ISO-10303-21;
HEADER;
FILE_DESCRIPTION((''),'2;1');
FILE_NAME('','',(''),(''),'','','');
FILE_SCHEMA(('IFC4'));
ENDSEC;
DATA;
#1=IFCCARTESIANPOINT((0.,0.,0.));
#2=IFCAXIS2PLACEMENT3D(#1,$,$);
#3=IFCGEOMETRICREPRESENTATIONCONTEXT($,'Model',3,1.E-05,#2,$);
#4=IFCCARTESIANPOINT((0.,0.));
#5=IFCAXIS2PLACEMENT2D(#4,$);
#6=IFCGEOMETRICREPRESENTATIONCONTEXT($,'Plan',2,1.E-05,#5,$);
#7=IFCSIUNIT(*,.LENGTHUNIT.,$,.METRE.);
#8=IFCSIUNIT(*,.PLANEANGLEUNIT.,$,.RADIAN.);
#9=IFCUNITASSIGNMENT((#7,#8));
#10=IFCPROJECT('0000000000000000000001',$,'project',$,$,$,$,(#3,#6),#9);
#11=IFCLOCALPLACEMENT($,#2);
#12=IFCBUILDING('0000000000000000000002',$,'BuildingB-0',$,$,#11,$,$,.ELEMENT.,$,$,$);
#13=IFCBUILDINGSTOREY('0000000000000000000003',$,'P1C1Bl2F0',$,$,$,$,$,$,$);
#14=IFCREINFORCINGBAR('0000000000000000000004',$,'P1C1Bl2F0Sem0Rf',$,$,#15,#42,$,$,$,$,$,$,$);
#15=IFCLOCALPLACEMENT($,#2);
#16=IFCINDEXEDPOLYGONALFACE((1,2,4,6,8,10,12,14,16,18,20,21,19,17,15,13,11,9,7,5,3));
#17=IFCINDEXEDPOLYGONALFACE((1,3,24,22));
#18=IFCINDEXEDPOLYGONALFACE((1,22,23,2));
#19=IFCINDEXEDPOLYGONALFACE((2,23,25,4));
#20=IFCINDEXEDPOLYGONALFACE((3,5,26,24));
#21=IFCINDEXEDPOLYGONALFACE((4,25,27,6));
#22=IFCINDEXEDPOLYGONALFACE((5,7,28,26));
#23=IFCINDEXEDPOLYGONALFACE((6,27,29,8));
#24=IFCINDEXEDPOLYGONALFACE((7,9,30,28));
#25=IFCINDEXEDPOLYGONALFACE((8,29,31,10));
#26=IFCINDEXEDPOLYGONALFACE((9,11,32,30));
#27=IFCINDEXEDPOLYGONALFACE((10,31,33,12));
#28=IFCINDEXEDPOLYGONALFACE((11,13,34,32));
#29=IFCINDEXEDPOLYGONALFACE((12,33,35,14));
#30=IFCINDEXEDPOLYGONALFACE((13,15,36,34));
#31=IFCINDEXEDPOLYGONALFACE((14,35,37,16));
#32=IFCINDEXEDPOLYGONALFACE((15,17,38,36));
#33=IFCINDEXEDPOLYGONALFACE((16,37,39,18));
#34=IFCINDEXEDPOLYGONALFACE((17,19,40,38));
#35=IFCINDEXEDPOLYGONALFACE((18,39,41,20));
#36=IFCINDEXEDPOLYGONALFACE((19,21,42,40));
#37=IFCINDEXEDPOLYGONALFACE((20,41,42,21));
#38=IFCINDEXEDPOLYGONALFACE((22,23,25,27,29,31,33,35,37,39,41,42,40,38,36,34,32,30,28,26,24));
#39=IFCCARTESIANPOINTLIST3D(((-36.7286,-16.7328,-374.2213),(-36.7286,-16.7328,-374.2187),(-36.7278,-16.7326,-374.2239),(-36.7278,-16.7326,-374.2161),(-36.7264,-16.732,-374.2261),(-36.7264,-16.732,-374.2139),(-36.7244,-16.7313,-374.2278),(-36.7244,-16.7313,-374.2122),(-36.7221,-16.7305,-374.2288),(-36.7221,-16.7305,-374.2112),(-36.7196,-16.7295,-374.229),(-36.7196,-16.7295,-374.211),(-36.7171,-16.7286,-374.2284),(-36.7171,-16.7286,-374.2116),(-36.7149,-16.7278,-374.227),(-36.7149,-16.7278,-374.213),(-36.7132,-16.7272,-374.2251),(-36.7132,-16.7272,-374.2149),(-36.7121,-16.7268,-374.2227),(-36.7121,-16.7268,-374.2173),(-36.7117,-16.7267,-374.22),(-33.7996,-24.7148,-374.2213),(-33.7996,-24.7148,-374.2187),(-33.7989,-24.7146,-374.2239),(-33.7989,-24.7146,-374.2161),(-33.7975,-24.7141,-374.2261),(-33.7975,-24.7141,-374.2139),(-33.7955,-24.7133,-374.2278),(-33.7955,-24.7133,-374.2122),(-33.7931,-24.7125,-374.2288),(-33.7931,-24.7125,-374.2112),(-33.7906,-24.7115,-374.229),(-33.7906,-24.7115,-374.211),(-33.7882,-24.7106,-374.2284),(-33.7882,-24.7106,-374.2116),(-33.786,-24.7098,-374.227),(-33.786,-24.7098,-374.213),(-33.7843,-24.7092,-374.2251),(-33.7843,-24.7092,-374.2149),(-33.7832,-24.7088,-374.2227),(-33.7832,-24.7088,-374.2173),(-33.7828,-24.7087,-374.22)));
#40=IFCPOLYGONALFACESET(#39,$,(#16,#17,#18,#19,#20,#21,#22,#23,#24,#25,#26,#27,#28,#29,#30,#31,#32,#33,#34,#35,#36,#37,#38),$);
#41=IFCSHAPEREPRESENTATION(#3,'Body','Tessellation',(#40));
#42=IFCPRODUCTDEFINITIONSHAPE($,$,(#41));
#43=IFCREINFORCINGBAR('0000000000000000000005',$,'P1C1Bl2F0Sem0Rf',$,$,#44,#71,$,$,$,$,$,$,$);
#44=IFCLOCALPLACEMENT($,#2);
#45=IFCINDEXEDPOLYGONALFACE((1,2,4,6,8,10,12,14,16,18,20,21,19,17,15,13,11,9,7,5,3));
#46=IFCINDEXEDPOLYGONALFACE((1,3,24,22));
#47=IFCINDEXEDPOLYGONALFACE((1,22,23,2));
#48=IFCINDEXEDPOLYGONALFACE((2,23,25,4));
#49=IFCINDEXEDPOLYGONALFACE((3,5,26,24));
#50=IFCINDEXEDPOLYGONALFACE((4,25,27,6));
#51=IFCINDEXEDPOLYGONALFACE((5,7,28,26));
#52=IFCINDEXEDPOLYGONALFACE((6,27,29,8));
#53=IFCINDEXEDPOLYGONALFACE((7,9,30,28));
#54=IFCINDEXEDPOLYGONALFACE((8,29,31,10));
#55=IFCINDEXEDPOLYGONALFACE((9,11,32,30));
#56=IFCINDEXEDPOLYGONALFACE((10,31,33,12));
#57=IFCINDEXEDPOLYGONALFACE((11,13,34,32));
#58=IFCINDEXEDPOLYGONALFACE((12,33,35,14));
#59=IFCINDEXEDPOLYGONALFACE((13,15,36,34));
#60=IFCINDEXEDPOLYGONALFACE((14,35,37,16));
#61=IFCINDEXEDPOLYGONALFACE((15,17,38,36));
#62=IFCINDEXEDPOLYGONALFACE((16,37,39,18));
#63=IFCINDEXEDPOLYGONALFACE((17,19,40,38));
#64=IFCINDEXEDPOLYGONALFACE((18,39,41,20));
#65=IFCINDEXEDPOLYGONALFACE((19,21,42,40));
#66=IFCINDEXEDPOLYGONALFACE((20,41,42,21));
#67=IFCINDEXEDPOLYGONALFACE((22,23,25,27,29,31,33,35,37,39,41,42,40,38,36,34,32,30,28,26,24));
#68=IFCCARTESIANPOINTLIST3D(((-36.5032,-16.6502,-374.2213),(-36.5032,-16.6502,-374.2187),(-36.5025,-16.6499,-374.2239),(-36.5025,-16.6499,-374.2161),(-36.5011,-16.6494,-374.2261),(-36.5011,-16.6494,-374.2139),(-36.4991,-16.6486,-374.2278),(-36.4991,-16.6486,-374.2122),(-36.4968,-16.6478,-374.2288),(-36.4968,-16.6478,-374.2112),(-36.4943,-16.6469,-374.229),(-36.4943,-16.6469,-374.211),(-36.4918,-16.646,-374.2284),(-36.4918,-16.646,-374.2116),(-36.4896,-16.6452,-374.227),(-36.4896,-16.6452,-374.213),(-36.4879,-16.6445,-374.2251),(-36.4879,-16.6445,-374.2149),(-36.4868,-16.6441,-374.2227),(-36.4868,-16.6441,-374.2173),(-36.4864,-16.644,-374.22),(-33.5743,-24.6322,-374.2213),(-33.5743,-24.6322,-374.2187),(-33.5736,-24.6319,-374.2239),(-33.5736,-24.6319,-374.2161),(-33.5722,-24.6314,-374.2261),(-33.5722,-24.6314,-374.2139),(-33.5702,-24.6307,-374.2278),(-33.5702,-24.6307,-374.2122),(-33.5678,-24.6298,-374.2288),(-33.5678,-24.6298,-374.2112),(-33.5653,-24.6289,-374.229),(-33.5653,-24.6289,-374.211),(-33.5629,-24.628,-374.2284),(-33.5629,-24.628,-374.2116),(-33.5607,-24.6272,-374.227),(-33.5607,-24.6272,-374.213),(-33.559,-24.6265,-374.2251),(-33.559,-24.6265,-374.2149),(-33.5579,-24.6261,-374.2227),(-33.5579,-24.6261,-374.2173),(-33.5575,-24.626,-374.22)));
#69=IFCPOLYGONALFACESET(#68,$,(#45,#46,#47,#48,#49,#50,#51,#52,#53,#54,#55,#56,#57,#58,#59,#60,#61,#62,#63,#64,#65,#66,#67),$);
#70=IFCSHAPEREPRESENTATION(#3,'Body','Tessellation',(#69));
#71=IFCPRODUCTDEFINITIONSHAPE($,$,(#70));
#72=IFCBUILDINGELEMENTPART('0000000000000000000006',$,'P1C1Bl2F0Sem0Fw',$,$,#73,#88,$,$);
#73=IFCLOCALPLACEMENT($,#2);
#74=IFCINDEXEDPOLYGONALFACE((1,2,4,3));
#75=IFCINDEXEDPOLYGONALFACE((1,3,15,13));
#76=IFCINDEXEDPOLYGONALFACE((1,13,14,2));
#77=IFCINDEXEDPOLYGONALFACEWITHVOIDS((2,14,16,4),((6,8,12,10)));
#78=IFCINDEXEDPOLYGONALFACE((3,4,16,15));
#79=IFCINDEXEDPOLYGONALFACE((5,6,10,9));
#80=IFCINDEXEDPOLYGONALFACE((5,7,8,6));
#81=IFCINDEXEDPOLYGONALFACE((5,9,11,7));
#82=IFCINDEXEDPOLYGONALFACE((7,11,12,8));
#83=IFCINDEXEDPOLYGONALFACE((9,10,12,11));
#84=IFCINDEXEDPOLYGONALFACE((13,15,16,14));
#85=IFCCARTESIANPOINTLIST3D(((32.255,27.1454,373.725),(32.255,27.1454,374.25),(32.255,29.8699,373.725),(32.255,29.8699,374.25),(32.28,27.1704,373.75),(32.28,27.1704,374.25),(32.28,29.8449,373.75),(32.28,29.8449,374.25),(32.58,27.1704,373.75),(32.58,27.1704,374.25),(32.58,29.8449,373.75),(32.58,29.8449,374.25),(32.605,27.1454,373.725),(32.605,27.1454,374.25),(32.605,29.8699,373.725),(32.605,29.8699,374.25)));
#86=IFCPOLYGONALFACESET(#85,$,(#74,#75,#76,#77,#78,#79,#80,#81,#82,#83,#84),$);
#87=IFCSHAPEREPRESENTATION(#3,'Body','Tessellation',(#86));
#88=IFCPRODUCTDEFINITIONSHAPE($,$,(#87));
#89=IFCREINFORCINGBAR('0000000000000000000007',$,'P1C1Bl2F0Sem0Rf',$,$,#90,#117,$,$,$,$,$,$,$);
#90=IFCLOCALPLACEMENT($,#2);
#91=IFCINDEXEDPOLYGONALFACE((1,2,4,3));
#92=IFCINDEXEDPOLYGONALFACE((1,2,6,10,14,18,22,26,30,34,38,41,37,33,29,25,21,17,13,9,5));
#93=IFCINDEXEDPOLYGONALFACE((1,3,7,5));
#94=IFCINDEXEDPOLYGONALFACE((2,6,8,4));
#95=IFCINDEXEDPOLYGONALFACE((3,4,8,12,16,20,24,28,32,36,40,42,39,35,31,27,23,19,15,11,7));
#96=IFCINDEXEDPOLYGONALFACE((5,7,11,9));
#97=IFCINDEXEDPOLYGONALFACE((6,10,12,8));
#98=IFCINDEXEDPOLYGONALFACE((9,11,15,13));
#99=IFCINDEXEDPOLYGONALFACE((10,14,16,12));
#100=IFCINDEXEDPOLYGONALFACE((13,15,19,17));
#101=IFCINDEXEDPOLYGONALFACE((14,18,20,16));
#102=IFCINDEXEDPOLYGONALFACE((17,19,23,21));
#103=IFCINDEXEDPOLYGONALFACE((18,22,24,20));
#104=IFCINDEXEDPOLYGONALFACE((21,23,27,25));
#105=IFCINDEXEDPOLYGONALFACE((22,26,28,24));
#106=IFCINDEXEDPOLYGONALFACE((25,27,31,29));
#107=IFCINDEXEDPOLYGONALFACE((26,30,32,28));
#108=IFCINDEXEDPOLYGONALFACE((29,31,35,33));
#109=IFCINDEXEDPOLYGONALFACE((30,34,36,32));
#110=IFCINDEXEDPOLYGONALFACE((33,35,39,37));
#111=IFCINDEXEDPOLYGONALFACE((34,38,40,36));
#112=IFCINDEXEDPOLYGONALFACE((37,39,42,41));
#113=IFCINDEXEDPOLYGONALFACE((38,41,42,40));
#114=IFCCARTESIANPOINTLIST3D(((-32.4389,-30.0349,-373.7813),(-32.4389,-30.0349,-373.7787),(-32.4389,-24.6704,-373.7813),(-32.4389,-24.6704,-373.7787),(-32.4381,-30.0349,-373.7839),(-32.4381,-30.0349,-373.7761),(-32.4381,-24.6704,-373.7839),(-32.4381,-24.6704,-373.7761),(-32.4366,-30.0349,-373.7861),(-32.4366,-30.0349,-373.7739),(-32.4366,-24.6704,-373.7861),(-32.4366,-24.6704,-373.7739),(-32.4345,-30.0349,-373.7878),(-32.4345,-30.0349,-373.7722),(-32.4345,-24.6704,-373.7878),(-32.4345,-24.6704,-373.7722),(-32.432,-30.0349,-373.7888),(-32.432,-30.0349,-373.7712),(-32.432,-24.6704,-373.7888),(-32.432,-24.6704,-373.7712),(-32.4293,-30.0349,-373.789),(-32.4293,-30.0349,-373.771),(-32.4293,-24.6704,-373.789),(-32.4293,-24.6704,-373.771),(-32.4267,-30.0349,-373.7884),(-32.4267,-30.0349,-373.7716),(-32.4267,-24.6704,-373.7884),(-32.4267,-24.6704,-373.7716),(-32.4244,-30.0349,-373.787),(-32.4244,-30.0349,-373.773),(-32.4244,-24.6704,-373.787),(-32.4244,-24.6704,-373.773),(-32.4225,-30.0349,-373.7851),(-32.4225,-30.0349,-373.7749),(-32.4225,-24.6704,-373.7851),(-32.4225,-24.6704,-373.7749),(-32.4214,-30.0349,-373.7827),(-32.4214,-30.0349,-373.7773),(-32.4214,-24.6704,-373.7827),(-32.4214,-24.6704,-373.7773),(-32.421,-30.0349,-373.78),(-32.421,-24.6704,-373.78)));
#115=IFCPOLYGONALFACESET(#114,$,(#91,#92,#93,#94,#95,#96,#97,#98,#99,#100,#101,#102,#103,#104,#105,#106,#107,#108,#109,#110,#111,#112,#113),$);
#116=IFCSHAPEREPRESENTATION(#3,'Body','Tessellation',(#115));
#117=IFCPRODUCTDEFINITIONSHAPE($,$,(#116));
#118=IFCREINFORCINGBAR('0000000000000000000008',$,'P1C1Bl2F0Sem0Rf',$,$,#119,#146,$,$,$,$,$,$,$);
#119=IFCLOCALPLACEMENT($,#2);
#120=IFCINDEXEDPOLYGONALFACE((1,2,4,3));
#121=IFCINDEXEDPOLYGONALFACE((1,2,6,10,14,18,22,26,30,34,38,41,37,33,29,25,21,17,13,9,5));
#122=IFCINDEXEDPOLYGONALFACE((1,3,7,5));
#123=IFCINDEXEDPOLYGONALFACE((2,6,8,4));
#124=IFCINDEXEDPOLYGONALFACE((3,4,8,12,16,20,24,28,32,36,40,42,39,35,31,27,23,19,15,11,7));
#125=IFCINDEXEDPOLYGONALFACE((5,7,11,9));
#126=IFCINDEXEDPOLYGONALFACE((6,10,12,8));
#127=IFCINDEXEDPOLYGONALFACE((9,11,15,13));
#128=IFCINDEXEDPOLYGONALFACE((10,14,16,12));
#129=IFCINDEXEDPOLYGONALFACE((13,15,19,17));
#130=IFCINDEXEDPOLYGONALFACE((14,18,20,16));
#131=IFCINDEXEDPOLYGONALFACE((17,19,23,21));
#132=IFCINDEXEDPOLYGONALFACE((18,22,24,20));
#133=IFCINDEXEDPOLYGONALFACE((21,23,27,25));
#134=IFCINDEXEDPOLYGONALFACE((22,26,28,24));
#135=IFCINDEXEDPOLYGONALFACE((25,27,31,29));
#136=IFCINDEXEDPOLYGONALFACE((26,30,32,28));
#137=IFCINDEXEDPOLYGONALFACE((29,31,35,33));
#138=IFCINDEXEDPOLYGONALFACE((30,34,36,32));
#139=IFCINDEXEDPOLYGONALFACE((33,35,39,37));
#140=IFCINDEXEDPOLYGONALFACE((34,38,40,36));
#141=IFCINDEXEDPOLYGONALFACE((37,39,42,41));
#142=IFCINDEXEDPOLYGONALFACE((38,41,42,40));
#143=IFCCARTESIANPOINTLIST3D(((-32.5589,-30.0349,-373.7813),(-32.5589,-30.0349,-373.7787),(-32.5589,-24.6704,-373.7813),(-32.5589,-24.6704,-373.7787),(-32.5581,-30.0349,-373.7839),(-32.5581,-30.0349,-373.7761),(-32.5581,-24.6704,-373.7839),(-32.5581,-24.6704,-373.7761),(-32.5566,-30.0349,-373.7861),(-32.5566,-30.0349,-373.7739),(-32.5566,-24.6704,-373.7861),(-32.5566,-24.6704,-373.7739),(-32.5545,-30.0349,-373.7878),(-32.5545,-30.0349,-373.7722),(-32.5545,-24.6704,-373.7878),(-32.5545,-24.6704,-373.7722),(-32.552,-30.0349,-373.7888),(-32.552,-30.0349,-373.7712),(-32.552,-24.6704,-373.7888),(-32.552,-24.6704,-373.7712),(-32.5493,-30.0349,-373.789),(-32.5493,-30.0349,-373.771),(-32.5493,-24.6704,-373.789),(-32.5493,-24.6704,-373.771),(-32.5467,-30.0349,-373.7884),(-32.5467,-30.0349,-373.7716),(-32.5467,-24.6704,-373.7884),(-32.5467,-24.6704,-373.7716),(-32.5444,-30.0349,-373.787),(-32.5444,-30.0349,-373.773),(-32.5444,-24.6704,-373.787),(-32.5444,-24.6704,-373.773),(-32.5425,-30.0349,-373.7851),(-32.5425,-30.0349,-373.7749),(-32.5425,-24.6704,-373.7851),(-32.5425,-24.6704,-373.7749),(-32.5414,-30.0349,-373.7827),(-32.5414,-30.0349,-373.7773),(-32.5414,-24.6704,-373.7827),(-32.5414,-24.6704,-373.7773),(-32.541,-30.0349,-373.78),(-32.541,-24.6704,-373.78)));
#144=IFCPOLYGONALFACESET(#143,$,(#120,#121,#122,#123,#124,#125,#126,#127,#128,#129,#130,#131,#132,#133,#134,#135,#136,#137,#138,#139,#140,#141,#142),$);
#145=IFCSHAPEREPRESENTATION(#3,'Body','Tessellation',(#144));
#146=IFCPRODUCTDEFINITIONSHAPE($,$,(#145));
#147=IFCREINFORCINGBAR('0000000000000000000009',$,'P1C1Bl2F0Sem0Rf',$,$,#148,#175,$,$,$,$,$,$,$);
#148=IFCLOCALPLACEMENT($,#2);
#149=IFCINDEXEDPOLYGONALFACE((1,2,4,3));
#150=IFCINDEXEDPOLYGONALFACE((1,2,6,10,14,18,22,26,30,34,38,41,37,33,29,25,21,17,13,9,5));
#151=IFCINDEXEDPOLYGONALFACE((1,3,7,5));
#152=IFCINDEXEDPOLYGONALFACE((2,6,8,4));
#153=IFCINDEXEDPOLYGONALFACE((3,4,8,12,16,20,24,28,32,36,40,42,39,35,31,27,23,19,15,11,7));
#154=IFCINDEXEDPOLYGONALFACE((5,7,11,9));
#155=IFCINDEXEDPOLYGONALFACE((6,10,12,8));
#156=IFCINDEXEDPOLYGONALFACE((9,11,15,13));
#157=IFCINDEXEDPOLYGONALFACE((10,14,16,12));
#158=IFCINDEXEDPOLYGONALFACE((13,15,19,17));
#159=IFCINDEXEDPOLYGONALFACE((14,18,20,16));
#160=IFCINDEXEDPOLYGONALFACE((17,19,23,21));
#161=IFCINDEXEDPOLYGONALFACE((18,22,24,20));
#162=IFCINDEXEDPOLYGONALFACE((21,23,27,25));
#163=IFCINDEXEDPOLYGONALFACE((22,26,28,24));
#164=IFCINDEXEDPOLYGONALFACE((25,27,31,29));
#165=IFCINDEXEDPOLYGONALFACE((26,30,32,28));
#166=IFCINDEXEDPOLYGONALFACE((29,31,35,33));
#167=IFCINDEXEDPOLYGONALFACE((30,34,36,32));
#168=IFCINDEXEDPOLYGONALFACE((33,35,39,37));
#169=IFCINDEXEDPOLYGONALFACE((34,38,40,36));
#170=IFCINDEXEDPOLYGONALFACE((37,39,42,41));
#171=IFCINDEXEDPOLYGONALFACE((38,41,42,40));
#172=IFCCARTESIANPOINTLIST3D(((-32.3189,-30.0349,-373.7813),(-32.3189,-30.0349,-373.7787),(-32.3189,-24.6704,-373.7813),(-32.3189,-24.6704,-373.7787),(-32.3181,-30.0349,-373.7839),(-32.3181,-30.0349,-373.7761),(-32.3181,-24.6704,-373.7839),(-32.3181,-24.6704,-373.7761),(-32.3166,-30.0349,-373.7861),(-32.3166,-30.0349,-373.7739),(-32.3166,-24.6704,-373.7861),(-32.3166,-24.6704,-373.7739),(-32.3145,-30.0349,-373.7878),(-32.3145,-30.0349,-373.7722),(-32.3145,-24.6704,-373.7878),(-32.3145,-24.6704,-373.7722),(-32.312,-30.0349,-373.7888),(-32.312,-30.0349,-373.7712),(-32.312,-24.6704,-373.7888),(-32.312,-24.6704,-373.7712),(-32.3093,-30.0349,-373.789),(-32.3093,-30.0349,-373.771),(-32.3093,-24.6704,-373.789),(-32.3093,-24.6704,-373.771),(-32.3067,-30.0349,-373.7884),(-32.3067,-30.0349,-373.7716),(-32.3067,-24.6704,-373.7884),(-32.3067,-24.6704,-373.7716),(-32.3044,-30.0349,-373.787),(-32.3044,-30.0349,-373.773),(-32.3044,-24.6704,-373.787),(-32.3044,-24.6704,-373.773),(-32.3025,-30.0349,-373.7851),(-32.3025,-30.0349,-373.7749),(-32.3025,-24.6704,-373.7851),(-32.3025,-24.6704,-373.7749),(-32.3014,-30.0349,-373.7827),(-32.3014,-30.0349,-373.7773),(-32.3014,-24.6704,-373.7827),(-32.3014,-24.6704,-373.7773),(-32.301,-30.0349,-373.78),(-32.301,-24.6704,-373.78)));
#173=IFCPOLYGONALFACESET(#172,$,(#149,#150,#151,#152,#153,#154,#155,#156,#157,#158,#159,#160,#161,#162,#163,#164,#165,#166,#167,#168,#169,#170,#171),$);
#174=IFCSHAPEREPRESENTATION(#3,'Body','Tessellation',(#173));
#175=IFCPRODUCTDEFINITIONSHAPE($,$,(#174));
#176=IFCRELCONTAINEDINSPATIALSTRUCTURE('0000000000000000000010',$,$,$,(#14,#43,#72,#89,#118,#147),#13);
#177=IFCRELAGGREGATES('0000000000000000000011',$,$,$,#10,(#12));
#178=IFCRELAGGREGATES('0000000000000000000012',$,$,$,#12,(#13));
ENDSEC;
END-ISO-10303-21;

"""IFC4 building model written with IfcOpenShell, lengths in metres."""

from ifc_helpers import new_model, entity, si_unit, origin, origin_2d, place, context, project, spatial, polyline, outline, extrude, element, save


model = new_model("IFC4")

# Units and contexts
model_context = context("Model", 3, precision=1e-05, world=origin())
plan_context = context("Plan", 2, precision=1e-05, world=origin_2d())
ifc_project = project(units=[si_unit("LENGTHUNIT", "METRE"), si_unit("PLANEANGLEUNIT", "RADIAN")], contexts=[model_context, plan_context])

# Building, storey
building_placement = place(None, origin())
building = spatial("IfcBuilding", under=ifc_project, at=building_placement, Name="BuildingB-0", CompositionType="ELEMENT")
storey = spatial("IfcBuildingStorey", under=building, Name="P1C1Bl2F0")

# Reinforcing bars
element("IfcReinforcingBar", 1, inside=storey, Name="P1C1Bl2F0Sem0Rf", context=model_context, shape_type="SweptSolid", body=[
    entity("IfcSurfaceCurveSweptAreaSolid", entity("IfcCircleProfileDef", "AREA", None, None, 0.009), None, entity("IfcPolyline", [entity("IfcCartesianPoint", [36.7202, 16.7298, 374.22]), entity("IfcCartesianPoint", [33.7913, 24.7118, 374.22])]), None, None, entity("IfcPlane", entity("IfcAxis2Placement3D", entity("IfcCartesianPoint", [36.7202, 16.7298, 374.22]), entity("IfcDirection", [0.0, 0.0, 1.0]), entity("IfcDirection", [1.0, 0.0, 0.0])))),
])
element("IfcReinforcingBar", 2, inside=storey, Name="P1C1Bl2F0Sem0Rf", context=model_context, shape_type="SweptSolid", body=[
    entity("IfcSurfaceCurveSweptAreaSolid", entity("IfcCircleProfileDef", "AREA", None, None, 0.009), None, entity("IfcPolyline", [entity("IfcCartesianPoint", [36.4949, 16.6471, 374.22]), entity("IfcCartesianPoint", [33.566, 24.6291, 374.22])]), None, None, entity("IfcPlane", entity("IfcAxis2Placement3D", entity("IfcCartesianPoint", [36.4949, 16.6471, 374.22]), entity("IfcDirection", [0.0, 0.0, 1.0]), entity("IfcDirection", [1.0, 0.0, 0.0])))),
])

# Building element part, opening
building_element_part_1 = element("IfcBuildingElementPart", 3, inside=storey, Name="P1C1Bl2F0Sem0Fw", context=model_context, shape_type="SweptSolid", body=[
    extrude(outline(polyline([(32.255, 27.1454, 373.725), (32.605, 27.1454, 373.725), (32.605, 29.8699, 373.725), (32.255, 29.8699, 373.725), (32.255, 27.1454, 373.725)])), None, (0.0, 0.0, 1.0), 0.525),
])
element("IfcOpeningElement", 4, inside=storey, cuts=building_element_part_1, context=model_context, shape_type="SweptSolid", body=[
    extrude(outline(polyline([(32.28, 27.1704, 373.75), (32.58, 27.1704, 373.75), (32.58, 29.8449, 373.75), (32.28, 29.8449, 373.75), (32.28, 27.1704, 373.75)])), None, (0.0, 0.0, 1.0), 0.5),
])

# Reinforcing bars
element("IfcReinforcingBar", 5, inside=storey, Name="P1C1Bl2F0Sem0Rf", context=model_context, shape_type="SweptSolid", body=[
    entity("IfcSurfaceCurveSweptAreaSolid", entity("IfcCircleProfileDef", "AREA", None, None, 0.009), None, entity("IfcPolyline", [entity("IfcCartesianPoint", [32.43, 24.6704, 373.78]), entity("IfcCartesianPoint", [32.43, 30.0349, 373.78])]), None, None, entity("IfcPlane", entity("IfcAxis2Placement3D", entity("IfcCartesianPoint", [32.43, 24.6704, 373.78]), entity("IfcDirection", [0.0, 0.0, 1.0]), entity("IfcDirection", [1.0, 0.0, 0.0])))),
])
element("IfcReinforcingBar", 6, inside=storey, Name="P1C1Bl2F0Sem0Rf", context=model_context, shape_type="SweptSolid", body=[
    entity("IfcSurfaceCurveSweptAreaSolid", entity("IfcCircleProfileDef", "AREA", None, None, 0.009), None, entity("IfcPolyline", [entity("IfcCartesianPoint", [32.55, 24.6704, 373.78]), entity("IfcCartesianPoint", [32.55, 30.0349, 373.78])]), None, None, entity("IfcPlane", entity("IfcAxis2Placement3D", entity("IfcCartesianPoint", [32.55, 24.6704, 373.78]), entity("IfcDirection", [0.0, 0.0, 1.0]), entity("IfcDirection", [1.0, 0.0, 0.0])))),
])
element("IfcReinforcingBar", 7, inside=storey, Name="P1C1Bl2F0Sem0Rf", context=model_context, shape_type="SweptSolid", body=[
    entity("IfcSurfaceCurveSweptAreaSolid", entity("IfcCircleProfileDef", "AREA", None, None, 0.009), None, entity("IfcPolyline", [entity("IfcCartesianPoint", [32.31, 24.6704, 373.78]), entity("IfcCartesianPoint", [32.31, 30.0349, 373.78])]), None, None, entity("IfcPlane", entity("IfcAxis2Placement3D", entity("IfcCartesianPoint", [32.31, 24.6704, 373.78]), entity("IfcDirection", [0.0, 0.0, 1.0]), entity("IfcDirection", [1.0, 0.0, 0.0])))),
])

save(model, "model.ifc")
